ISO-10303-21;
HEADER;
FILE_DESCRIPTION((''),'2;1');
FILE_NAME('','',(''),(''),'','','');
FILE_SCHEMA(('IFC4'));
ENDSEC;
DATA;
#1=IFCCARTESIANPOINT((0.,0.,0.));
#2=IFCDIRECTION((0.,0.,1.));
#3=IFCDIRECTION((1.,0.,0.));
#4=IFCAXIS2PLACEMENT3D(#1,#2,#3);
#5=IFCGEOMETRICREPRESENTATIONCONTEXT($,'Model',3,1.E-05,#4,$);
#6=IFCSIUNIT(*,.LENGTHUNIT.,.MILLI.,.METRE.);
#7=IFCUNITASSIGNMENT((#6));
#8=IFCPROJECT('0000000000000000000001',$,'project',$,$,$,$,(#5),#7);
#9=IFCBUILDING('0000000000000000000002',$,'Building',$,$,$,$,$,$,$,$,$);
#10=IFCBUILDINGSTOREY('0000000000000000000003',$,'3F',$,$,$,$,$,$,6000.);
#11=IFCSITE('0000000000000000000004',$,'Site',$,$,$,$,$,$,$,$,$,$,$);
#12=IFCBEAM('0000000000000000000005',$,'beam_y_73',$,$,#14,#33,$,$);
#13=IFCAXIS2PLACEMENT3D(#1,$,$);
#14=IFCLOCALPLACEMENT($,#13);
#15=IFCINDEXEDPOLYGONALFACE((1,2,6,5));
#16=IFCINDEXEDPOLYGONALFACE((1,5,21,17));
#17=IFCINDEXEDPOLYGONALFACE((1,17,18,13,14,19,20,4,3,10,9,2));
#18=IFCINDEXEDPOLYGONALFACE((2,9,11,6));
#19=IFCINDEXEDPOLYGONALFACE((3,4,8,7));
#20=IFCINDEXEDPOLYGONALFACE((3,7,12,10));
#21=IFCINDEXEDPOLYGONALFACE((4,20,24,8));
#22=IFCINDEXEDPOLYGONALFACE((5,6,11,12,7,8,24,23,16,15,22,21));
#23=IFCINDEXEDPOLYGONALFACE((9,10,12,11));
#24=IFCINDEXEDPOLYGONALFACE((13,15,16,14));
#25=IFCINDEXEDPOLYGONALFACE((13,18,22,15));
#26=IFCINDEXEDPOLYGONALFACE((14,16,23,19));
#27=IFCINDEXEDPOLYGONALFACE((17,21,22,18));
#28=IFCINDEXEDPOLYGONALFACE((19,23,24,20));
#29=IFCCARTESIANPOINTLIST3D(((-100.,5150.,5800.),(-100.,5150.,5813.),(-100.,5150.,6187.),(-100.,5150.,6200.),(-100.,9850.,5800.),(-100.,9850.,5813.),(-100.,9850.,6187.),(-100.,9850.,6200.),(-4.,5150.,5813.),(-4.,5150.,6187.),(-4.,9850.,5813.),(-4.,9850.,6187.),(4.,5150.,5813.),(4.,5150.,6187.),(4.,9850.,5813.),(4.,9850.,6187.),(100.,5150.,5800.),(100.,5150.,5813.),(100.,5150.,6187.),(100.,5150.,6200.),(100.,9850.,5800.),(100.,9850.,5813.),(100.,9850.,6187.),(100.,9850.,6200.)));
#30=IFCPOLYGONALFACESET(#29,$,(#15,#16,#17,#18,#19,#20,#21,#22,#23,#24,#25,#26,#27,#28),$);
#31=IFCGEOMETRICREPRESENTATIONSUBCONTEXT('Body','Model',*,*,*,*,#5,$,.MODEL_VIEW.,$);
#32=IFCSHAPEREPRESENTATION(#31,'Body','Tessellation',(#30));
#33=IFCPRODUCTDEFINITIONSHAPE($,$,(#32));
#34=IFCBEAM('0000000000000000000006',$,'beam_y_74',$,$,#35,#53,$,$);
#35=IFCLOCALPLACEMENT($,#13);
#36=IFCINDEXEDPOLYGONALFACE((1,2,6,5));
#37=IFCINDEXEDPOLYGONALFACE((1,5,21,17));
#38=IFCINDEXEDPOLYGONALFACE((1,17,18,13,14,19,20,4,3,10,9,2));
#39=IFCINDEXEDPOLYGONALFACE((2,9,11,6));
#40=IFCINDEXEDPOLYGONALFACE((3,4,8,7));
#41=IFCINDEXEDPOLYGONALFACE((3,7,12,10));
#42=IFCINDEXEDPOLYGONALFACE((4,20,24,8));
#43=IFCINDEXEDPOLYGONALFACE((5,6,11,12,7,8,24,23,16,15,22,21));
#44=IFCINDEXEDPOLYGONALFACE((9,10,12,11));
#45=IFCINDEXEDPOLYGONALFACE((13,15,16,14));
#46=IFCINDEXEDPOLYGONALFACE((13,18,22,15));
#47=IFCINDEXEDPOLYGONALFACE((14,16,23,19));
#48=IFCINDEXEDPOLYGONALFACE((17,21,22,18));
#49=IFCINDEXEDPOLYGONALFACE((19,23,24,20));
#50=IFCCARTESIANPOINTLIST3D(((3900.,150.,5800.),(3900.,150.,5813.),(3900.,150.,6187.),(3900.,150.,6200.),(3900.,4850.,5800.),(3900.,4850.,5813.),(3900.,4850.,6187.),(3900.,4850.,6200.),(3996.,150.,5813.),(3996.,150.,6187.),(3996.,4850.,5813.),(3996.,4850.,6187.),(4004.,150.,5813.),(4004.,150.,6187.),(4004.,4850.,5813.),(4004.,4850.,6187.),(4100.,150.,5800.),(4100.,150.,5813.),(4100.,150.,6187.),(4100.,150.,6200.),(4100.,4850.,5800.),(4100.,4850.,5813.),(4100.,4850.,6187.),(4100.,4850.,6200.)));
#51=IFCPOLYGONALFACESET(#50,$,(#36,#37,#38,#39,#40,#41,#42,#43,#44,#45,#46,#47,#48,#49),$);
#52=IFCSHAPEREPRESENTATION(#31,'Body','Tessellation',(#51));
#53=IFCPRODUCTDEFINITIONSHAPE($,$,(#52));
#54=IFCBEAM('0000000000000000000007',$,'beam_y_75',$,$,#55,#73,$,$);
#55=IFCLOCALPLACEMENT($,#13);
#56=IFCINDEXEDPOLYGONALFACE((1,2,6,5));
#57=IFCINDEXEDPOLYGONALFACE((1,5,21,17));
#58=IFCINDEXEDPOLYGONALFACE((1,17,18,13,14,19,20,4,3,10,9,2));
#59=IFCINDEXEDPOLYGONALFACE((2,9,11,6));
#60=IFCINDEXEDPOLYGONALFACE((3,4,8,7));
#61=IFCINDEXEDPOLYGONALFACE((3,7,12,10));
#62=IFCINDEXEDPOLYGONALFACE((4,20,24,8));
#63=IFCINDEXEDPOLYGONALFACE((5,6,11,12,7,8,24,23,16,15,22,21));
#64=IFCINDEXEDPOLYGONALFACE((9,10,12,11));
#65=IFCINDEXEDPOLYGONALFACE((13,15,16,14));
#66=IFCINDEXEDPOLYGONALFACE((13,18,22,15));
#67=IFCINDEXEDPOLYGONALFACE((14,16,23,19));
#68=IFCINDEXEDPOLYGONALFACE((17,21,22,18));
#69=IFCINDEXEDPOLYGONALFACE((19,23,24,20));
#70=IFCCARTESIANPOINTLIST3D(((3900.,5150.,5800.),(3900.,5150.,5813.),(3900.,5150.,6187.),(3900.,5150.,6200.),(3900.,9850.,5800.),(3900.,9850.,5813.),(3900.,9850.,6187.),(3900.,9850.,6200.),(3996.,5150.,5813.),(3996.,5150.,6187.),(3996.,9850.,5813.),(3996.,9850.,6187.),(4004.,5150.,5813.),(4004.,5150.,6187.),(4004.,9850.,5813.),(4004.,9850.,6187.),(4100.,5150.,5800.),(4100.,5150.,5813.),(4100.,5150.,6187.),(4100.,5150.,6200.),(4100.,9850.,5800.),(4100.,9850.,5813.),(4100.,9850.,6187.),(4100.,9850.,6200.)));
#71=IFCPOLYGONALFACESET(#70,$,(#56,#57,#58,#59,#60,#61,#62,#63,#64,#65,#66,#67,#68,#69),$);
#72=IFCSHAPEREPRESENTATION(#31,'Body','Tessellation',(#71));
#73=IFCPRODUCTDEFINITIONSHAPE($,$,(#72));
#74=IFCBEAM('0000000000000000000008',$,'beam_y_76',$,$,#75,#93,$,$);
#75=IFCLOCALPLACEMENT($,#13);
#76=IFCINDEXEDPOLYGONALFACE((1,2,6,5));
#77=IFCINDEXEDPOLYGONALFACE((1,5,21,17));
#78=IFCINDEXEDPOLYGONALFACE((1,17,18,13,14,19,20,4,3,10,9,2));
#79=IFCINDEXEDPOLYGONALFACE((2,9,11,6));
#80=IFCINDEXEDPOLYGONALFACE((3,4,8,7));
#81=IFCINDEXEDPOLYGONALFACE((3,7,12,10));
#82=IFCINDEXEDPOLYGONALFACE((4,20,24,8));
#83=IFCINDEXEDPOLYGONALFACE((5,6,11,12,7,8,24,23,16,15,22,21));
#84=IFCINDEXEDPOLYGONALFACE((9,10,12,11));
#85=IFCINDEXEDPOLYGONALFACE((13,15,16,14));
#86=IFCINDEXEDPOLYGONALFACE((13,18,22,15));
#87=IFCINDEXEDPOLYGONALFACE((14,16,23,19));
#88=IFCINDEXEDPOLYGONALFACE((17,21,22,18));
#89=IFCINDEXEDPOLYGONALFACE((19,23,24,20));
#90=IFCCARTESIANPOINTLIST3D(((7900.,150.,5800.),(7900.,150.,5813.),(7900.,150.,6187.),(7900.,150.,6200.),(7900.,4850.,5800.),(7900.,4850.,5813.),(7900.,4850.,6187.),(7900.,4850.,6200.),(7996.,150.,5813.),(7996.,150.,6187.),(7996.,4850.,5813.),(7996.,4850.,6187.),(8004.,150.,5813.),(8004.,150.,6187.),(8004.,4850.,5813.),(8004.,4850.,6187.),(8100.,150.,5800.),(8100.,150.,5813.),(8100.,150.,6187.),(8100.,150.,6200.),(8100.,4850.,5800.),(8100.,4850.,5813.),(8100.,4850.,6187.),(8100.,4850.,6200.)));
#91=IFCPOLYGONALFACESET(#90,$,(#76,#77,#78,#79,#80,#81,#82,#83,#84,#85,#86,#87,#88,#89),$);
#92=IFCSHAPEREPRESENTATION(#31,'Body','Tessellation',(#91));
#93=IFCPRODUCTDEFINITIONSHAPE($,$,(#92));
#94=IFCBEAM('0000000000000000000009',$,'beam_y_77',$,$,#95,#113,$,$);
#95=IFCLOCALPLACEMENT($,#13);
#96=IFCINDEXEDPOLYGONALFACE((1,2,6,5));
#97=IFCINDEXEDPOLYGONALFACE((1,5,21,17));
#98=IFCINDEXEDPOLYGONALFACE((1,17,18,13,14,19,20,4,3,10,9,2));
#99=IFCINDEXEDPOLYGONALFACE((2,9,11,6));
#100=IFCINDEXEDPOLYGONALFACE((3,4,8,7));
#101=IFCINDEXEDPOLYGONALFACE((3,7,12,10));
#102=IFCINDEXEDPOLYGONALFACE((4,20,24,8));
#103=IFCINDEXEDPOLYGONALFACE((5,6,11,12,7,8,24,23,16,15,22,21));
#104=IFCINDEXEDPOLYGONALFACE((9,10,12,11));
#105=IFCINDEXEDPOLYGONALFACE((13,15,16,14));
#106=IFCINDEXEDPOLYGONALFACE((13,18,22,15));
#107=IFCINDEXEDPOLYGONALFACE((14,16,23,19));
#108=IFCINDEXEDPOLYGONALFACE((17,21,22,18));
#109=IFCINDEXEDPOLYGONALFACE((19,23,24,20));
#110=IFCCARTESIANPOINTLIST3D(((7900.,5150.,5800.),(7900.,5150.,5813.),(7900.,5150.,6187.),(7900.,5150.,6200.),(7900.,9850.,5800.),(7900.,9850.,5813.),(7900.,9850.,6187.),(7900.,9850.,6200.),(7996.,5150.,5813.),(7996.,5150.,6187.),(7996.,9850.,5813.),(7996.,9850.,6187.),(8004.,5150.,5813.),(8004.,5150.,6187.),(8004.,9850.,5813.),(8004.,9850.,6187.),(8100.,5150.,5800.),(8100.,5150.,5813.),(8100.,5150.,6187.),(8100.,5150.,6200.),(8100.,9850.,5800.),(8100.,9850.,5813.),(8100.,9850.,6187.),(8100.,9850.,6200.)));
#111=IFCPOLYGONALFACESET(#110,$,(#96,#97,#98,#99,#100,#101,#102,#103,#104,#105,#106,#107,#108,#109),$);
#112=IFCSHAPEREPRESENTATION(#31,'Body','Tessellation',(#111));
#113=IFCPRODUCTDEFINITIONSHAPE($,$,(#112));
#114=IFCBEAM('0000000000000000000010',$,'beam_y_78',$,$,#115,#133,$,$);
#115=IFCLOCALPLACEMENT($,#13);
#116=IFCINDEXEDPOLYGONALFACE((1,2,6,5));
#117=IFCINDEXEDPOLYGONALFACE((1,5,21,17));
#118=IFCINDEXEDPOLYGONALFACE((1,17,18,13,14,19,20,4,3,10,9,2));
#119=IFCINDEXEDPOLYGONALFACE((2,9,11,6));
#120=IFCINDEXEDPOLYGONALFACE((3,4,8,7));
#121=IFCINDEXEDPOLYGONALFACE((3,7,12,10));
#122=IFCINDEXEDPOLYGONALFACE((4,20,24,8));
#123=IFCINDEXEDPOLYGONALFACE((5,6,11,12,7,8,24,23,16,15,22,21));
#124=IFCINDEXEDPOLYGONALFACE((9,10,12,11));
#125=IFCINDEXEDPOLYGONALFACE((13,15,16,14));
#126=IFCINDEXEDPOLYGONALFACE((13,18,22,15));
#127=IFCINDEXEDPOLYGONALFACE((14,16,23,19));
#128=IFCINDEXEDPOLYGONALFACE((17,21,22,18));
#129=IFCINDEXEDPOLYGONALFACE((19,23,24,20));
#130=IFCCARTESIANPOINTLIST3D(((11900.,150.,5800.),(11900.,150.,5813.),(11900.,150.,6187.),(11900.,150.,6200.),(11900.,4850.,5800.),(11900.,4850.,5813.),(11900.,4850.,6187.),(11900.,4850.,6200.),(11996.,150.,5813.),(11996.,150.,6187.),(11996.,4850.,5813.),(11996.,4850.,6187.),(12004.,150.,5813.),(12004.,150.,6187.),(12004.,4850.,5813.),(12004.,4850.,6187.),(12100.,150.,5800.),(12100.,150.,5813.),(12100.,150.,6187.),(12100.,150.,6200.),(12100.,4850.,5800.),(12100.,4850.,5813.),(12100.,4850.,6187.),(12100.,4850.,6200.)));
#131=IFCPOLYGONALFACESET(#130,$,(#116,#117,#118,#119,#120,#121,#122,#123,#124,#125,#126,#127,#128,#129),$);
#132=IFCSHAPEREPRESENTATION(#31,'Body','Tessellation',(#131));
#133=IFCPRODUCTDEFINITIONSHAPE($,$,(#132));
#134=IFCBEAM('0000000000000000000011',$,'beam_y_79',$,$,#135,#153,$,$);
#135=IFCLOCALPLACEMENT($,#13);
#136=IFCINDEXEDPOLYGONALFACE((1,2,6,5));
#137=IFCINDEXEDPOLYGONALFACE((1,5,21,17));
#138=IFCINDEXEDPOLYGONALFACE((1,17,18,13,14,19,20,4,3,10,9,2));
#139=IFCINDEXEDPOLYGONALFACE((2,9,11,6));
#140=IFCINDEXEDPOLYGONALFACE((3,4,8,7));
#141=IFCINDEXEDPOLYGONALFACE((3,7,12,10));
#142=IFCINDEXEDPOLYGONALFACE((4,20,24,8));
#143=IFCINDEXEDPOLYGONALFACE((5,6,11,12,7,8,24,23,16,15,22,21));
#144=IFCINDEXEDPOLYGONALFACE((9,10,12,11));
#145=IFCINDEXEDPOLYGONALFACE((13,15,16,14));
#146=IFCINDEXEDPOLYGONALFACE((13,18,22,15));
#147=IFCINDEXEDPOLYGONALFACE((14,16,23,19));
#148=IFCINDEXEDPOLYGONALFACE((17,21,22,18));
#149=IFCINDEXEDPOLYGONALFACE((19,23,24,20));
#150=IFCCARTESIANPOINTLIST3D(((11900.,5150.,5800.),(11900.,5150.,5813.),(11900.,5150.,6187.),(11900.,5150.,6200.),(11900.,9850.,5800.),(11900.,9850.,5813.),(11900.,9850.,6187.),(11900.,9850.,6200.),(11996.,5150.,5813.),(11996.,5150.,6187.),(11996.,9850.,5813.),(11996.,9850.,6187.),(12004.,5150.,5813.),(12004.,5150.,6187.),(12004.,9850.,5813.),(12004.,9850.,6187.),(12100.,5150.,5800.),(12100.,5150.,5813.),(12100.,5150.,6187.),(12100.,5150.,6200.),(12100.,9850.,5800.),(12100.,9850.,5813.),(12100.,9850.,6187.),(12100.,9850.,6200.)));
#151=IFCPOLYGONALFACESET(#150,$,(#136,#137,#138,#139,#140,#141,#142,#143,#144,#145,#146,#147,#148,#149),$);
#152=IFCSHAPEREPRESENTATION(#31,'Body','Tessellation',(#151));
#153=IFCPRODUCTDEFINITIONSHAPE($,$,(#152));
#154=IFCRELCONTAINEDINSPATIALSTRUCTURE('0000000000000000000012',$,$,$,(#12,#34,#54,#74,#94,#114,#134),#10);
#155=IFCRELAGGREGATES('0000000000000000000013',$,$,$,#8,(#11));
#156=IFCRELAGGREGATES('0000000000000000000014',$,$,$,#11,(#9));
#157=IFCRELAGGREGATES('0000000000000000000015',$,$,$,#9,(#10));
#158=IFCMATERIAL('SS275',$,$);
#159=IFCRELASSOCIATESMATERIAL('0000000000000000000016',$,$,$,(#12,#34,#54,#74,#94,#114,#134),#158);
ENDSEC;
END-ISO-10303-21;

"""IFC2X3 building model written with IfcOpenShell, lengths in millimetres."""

from ifc_helpers import new_model, si_unit, frame, origin, origin_with_axes, origin_2d_with_axis, place, context, subcontext, project, spatial, i_section, extrude, material, element, save


model = new_model("IFC2X3")

# Units and contexts
model_context = context("Model", 3, precision=1e-05, world=origin_with_axes())
body_context = subcontext(model_context, "Body", "Model", "MODEL_VIEW")
ifc_project = project(units=[si_unit("LENGTHUNIT", "METRE", prefix="MILLI")], contexts=[model_context])

# Site, building, storey
site = spatial("IfcSite", under=ifc_project, Name="Site")
building = spatial("IfcBuilding", under=site, Name="Building")
storey = spatial("IfcBuildingStorey", under=building, Name="3F", Elevation=6000.0)

# Shared definitions
ifc_material = material(Name="SS275")

# Beams
for number, where, z_axis, x_axis, name in (
    (1, (0.0, 5150.0, 6000.0), (0.0, 1.0, 0.0), (-1.0, 0.0, 0.0), "beam_y_73"),
    (2, (4000.0, 150.0, 6000.0), (0.0, 1.0, 0.0), (-1.0, 0.0, 0.0), "beam_y_74"),
    (3, (4000.0, 5150.0, 6000.0), (0.0, 1.0, 0.0), (-1.0, 0.0, 0.0), "beam_y_75"),
    (4, (8000.0, 150.0, 6000.0), (0.0, 1.0, 0.0), (-1.0, 0.0, 0.0), "beam_y_76"),
    (5, (8000.0, 5150.0, 6000.0), (0.0, 1.0, 0.0), (-1.0, 0.0, 0.0), "beam_y_77"),
    (6, (12000.0, 150.0, 6000.0), (0.0, 1.0, 0.0), (-1.0, 0.0, 0.0), "beam_y_78"),
    (7, (12000.0, 5150.0, 6000.0), (0.0, 1.0, 0.0), (-1.0, 0.0, 0.0), "beam_y_79"),
):
    element("IfcBeam", number, at=place(None, frame(where, z_axis=z_axis, x_axis=x_axis)), inside=storey, material=ifc_material, Name=name, context=body_context, shape_type="SweptSolid", body=[
        extrude(i_section(OverallWidth=200.0, OverallDepth=400.0, WebThickness=8.0, FlangeThickness=13.0, at=origin_2d_with_axis()), origin(), (0.0, 0.0, 1.0), 4700.0),
    ])

save(model, "model.ifc")
